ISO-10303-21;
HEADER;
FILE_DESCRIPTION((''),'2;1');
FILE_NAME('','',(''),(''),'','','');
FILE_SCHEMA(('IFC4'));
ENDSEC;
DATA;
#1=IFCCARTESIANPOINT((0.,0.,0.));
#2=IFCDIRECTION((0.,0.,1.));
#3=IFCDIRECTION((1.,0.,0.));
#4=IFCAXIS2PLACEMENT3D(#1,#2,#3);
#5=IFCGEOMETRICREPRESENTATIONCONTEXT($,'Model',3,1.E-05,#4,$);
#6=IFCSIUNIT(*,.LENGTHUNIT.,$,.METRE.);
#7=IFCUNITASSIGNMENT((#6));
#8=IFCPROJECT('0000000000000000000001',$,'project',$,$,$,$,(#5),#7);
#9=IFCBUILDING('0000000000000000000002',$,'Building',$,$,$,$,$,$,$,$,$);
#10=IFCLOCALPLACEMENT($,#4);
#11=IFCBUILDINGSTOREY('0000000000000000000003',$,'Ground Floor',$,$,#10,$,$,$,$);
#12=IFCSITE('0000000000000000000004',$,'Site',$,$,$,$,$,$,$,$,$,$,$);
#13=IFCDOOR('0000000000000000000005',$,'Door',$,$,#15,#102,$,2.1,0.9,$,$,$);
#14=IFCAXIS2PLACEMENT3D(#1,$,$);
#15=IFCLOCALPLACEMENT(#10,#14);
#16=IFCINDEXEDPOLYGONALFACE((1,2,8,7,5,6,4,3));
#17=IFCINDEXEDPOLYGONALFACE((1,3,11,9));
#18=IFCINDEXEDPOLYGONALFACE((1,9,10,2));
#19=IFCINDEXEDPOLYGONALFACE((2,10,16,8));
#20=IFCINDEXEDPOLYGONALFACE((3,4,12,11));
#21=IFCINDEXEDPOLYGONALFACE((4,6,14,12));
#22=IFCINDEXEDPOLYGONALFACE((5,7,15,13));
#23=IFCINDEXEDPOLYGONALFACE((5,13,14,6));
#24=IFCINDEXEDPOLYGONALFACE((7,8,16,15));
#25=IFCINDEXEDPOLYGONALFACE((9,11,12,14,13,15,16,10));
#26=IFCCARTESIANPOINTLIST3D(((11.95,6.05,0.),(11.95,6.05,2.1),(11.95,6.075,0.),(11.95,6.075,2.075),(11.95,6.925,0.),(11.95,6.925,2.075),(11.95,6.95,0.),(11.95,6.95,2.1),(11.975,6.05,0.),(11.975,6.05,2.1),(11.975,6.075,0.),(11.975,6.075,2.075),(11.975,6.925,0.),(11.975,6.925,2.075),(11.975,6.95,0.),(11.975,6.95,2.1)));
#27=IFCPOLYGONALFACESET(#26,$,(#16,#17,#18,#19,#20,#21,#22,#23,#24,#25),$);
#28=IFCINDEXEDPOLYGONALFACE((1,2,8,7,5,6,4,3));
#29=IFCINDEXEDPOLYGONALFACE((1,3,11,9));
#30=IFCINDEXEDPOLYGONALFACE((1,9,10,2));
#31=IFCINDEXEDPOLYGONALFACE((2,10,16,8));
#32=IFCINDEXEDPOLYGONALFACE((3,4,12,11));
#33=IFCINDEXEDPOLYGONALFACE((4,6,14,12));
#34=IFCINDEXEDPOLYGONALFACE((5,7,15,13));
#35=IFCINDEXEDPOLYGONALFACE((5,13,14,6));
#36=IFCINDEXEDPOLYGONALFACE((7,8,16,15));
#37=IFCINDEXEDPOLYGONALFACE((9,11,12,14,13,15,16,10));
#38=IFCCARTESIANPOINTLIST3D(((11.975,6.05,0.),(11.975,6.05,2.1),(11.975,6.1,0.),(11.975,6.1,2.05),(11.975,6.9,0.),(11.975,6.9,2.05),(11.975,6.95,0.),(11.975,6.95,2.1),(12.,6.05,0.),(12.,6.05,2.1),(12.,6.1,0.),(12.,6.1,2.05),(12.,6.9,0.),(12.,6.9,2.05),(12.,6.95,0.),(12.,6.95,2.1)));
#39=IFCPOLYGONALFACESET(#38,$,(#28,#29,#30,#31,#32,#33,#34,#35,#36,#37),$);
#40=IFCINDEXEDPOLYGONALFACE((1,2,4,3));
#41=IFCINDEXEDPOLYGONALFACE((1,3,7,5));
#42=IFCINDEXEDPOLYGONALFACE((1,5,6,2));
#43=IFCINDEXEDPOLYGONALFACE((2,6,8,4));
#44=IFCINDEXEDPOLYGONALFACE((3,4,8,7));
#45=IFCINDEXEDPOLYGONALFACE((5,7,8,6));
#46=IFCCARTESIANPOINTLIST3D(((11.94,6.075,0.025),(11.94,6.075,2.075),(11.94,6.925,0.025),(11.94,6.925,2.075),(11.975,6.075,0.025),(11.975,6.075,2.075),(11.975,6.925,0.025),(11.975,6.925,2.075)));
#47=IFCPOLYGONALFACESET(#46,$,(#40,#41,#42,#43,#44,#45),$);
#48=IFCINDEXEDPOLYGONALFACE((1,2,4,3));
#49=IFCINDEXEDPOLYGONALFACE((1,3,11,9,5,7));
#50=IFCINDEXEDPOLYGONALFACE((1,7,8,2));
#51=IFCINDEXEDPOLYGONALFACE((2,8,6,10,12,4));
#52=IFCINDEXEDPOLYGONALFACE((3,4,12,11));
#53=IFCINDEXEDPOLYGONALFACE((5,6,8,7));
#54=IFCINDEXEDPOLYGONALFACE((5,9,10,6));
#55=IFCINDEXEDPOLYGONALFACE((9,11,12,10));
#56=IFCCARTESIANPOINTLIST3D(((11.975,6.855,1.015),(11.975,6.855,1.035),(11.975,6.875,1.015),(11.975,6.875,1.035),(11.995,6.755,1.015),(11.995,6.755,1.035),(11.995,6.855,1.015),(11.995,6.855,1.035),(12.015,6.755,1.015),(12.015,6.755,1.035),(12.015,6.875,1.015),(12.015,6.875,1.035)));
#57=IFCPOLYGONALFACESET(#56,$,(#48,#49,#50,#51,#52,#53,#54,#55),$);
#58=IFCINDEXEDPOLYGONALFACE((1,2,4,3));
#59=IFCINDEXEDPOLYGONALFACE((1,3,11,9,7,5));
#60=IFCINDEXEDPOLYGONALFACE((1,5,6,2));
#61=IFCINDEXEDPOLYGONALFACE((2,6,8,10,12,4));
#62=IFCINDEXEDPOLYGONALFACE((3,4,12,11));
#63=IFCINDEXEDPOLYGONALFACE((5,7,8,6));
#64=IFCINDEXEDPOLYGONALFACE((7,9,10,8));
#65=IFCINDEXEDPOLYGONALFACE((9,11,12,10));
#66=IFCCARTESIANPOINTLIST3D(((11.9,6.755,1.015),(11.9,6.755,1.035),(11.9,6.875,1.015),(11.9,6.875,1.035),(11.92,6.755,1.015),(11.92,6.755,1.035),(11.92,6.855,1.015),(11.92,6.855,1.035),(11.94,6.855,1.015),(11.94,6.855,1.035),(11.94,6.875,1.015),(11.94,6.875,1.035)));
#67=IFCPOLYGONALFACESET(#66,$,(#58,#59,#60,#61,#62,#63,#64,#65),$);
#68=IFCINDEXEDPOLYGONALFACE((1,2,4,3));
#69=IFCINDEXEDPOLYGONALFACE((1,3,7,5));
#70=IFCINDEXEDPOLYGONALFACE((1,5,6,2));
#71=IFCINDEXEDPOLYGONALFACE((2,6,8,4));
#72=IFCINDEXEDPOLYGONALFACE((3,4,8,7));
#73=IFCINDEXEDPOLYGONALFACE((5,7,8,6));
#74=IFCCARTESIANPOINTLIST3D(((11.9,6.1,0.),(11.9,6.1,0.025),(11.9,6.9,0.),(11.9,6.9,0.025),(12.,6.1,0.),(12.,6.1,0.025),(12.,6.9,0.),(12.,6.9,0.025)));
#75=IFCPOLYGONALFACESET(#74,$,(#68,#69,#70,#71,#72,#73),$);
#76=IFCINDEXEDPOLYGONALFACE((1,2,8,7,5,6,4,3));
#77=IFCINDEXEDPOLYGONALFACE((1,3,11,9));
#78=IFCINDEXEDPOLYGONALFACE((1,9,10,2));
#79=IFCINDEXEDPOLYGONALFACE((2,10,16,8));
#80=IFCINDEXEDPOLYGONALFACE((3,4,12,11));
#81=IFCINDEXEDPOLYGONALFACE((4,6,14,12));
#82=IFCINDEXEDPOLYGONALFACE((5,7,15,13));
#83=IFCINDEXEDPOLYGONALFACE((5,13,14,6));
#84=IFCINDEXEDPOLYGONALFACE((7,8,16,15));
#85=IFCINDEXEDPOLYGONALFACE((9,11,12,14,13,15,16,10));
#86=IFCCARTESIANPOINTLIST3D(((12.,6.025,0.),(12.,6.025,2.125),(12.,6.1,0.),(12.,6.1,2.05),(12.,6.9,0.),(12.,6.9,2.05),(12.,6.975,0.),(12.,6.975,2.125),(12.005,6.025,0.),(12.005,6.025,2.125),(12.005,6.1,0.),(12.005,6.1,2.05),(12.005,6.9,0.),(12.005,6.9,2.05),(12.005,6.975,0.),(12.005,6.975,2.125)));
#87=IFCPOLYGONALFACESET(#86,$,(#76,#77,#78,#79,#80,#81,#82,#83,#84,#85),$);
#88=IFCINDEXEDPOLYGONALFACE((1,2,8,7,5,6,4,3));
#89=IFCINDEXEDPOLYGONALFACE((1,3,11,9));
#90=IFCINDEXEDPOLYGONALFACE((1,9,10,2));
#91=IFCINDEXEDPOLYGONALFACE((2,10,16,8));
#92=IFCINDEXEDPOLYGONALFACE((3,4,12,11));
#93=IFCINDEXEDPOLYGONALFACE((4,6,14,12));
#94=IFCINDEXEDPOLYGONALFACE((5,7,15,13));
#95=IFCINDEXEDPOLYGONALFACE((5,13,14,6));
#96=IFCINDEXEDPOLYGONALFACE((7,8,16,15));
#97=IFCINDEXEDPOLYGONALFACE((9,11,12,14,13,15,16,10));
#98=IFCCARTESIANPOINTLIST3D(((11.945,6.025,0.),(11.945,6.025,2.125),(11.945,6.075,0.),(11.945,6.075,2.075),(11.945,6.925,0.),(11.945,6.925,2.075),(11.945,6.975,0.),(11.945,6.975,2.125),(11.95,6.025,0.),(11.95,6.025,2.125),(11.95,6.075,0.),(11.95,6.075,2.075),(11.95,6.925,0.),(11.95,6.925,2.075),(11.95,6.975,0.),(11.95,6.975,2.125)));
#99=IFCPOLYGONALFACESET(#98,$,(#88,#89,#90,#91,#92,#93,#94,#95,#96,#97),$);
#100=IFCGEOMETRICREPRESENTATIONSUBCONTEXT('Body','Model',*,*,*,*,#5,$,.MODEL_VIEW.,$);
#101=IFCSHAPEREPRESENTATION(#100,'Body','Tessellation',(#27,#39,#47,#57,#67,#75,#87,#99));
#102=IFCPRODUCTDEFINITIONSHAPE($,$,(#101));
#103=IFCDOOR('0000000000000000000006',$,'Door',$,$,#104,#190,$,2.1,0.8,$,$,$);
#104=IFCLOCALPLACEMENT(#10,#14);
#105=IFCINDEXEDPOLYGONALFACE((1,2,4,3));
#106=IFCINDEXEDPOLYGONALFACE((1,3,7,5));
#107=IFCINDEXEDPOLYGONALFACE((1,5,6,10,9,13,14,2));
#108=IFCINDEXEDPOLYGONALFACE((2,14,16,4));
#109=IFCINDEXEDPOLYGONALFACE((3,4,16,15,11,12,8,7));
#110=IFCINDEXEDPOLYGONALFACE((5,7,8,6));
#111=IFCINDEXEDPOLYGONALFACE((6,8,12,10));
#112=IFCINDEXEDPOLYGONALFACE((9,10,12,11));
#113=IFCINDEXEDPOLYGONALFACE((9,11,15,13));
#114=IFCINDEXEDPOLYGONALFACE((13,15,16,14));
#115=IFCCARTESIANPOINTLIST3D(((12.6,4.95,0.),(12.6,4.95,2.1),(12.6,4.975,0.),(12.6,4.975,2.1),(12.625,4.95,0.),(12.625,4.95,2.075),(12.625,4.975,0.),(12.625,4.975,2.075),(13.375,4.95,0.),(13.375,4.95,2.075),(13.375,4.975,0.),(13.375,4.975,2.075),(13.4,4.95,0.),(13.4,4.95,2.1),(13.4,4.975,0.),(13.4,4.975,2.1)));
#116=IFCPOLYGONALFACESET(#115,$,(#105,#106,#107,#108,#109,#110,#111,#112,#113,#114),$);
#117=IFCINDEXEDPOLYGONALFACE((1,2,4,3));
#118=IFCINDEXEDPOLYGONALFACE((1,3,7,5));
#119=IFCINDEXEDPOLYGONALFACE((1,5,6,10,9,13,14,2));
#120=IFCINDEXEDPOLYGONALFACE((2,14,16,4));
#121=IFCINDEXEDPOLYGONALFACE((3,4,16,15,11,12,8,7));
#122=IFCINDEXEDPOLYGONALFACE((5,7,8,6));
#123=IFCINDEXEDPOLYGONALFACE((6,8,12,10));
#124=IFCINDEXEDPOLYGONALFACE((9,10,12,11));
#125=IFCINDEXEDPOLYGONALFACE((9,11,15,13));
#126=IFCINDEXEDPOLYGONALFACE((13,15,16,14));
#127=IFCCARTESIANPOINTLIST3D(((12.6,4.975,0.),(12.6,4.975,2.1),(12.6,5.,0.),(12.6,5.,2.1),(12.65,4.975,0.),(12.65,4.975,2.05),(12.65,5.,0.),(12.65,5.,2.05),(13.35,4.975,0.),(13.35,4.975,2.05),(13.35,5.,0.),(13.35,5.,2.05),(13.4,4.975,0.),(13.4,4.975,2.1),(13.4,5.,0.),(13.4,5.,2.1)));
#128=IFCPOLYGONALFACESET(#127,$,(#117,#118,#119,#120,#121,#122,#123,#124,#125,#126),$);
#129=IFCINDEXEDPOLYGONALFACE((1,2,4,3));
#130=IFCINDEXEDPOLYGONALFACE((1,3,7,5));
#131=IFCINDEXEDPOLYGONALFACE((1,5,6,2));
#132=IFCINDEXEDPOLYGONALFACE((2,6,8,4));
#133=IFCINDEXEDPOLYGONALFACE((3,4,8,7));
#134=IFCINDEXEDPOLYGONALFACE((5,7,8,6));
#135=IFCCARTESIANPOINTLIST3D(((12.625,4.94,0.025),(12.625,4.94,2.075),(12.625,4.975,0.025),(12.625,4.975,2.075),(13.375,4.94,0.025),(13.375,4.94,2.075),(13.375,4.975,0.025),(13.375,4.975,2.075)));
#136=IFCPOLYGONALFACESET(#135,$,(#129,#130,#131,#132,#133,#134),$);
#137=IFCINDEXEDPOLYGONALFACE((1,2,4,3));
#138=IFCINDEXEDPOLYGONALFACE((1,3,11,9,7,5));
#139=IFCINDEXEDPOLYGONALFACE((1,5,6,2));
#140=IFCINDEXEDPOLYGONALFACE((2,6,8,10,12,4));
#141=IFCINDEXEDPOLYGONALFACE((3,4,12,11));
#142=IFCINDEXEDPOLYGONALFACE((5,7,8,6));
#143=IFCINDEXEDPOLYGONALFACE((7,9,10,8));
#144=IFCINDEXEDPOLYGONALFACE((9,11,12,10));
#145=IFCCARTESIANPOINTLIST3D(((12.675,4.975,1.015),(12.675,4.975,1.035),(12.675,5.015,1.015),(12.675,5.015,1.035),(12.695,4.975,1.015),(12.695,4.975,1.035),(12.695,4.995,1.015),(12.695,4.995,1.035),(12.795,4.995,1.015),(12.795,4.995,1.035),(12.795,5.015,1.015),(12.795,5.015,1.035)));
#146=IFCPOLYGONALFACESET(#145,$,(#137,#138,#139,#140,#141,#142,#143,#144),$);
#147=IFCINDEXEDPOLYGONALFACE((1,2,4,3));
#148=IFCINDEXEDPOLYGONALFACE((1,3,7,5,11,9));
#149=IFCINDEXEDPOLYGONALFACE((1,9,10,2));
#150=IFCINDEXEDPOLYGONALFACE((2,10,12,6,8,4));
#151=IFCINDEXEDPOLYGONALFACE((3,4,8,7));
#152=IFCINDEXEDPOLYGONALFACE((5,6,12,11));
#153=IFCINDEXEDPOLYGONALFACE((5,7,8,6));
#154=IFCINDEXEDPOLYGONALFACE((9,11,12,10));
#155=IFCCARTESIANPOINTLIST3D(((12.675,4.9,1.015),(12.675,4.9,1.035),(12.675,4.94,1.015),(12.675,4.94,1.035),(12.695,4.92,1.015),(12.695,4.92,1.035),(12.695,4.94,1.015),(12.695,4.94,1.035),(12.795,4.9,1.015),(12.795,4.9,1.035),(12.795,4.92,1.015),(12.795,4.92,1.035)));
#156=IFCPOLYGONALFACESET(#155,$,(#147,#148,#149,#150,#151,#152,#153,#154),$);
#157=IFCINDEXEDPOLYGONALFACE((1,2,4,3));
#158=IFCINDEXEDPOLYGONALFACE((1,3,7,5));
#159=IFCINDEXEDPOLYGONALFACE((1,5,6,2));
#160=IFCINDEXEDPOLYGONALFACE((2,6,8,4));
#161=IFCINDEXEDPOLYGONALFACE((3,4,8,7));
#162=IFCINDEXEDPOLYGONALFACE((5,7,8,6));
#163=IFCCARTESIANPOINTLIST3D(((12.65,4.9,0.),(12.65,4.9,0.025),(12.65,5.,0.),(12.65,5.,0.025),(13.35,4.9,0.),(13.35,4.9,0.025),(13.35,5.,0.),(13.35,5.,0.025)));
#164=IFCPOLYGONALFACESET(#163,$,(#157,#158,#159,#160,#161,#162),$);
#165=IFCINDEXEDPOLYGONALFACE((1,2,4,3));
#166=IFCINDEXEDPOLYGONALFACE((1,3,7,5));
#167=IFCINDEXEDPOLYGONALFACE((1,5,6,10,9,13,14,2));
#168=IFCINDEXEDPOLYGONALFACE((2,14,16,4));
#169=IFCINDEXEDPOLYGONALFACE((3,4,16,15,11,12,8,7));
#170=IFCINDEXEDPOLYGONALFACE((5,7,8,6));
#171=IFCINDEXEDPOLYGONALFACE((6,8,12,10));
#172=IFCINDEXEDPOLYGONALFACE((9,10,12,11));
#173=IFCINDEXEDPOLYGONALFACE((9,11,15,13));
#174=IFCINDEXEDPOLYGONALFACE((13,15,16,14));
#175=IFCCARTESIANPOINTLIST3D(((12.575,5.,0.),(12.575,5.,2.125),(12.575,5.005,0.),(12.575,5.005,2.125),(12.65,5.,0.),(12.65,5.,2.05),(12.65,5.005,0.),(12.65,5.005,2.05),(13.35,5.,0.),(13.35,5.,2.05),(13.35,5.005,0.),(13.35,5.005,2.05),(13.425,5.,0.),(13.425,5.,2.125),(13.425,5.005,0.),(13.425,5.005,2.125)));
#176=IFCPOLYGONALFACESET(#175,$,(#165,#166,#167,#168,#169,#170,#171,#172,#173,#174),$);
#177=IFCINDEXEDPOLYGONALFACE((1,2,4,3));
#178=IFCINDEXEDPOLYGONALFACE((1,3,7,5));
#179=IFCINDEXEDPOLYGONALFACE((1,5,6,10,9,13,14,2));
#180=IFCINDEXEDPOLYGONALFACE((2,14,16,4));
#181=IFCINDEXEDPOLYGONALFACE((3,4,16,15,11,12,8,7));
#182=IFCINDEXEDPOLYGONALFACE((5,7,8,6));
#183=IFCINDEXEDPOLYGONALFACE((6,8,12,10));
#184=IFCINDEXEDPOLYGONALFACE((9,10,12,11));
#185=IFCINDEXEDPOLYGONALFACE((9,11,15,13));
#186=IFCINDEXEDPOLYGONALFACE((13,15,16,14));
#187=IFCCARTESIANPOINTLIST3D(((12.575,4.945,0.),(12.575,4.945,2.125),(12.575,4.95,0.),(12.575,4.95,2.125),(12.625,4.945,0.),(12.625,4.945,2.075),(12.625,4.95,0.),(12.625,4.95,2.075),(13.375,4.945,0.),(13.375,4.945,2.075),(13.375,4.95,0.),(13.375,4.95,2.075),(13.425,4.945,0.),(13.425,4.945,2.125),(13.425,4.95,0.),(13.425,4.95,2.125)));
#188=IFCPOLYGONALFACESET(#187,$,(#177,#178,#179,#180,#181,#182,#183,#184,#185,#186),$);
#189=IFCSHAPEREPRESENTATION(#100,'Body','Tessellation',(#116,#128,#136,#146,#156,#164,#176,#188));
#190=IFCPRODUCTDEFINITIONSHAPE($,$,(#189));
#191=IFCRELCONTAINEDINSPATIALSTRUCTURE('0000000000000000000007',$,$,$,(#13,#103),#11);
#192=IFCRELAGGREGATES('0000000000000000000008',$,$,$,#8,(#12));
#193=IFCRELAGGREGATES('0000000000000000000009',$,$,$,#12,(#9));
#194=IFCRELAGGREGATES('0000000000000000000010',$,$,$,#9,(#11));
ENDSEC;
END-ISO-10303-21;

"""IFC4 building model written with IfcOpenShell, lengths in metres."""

from ifc_helpers import new_model, si_unit, frame, origin_with_axes, place, context, subcontext, project, spatial, line, indexed_curve, outline, extrude, element, save


model = new_model("IFC4")

# Units and contexts
model_context = context("Model", 3, precision=1e-05, world=origin_with_axes())
body_context = subcontext(model_context, "Body", "Model", "MODEL_VIEW")
ifc_project = project(units=[si_unit("LENGTHUNIT", "METRE")], contexts=[model_context])

# Site, building, storey
site = spatial("IfcSite", under=ifc_project, Name="Site")
building = spatial("IfcBuilding", under=site, Name="Building")
storey_placement = place(None, origin_with_axes())
storey = spatial("IfcBuildingStorey", under=building, at=storey_placement, Name="Ground Floor")

# Doors
door_1_placement = place(storey_placement, frame((12.0, 6.05, 0.0), z_axis=(0.0, 0.0, 1.0), x_axis=(0.0, 1.0, 0.0)))
element("IfcDoor", 1, at=door_1_placement, inside=storey, Name="Door", OverallHeight=2.1, OverallWidth=0.9, context=body_context, shape_type="SweptSolid", body=[
    extrude(outline(indexed_curve([(0.0, 0.0), (0.0, 2.1), (0.9, 2.1), (0.9, 0.0), (0.875, 0.0), (0.875, 2.075), (0.025, 2.075), (0.025, 0.0)], segments=[line(1, 2, 3, 4, 5, 6, 7, 8, 1)])), frame((0.0, 0.025, 0.0), z_axis=(0.0, -1.0, 0.0), x_axis=(1.0, 0.0, 0.0)), (0.0, 0.0, -1.0), 0.025),
    extrude(outline(indexed_curve([(0.0, 0.0), (0.0, 2.1), (0.9, 2.1), (0.9, 0.0), (0.85, 0.0), (0.85, 2.05), (0.05, 2.05), (0.05, 0.0)], segments=[line(1, 2, 3, 4, 5, 6, 7, 8, 1)])), frame((0.0, 0.0, 0.0), z_axis=(0.0, -1.0, 0.0), x_axis=(1.0, 0.0, 0.0)), (0.0, 0.0, -1.0), 0.025),
    extrude(outline(indexed_curve([(0.0, 0.0), (0.85, 0.0), (0.85, 0.035), (0.0, 0.035)], segments=[line(1, 2, 3, 4, 1)])), frame((0.025, 0.025, 0.025), z_axis=(0.0, 0.0, 1.0), x_axis=(1.0, 0.0, 0.0)), (0.0, 0.0, 1.0), 2.05),
    extrude(outline(indexed_curve([(0.0, 0.0), (0.0, -0.04), (-0.12, -0.04), (-0.12, -0.02), (-0.02, -0.02), (-0.02, 0.0)], segments=[line(1, 2, 3, 4, 5, 6, 1)])), frame((0.825, 0.025, 1.015), z_axis=(0.0, 0.0, 1.0), x_axis=(1.0, 0.0, 0.0)), (0.0, 0.0, 1.0), 0.02),
    extrude(outline(indexed_curve([(0.0, 0.0), (0.0, 0.04), (-0.12, 0.04), (-0.12, 0.02), (-0.02, 0.02), (-0.02, 0.0)], segments=[line(1, 2, 3, 4, 5, 6, 1)])), frame((0.825, 0.06, 1.015), z_axis=(0.0, 0.0, 1.0), x_axis=(1.0, 0.0, 0.0)), (0.0, 0.0, 1.0), 0.02),
    extrude(outline(indexed_curve([(0.0, 0.0), (0.8, 0.0), (0.8, 0.1), (0.0, 0.1)], segments=[line(1, 2, 3, 4, 1)])), frame((0.05, 0.0, 0.0), z_axis=(0.0, 0.0, 1.0), x_axis=(1.0, 0.0, 0.0)), (0.0, 0.0, 1.0), 0.025),
    extrude(outline(indexed_curve([(0.0, 0.0), (0.0, 2.125), (0.95, 2.125), (0.95, 0.0), (0.875, 0.0), (0.875, 2.05), (0.075, 2.05), (0.075, 0.0)], segments=[line(1, 2, 3, 4, 5, 6, 7, 8, 1)])), frame((-0.025, -0.005, 0.0), z_axis=(0.0, -1.0, 0.0), x_axis=(1.0, 0.0, 0.0)), (0.0, 0.0, -1.0), 0.005),
    extrude(outline(indexed_curve([(0.0, 0.0), (0.0, 2.125), (0.95, 2.125), (0.95, 0.0), (0.9, 0.0), (0.9, 2.075), (0.05, 2.075), (0.05, 0.0)], segments=[line(1, 2, 3, 4, 5, 6, 7, 8, 1)])), frame((-0.025, 0.05, 0.0), z_axis=(0.0, -1.0, 0.0), x_axis=(1.0, 0.0, 0.0)), (0.0, 0.0, -1.0), 0.005),
])
door_2_placement = place(storey_placement, frame((13.4, 5.0, 0.0), z_axis=(0.0, 0.0, 1.0), x_axis=(-1.0, 0.0, 0.0)))
element("IfcDoor", 2, at=door_2_placement, inside=storey, Name="Door", OverallHeight=2.1, OverallWidth=0.8, context=body_context, shape_type="SweptSolid", body=[
    extrude(outline(indexed_curve([(0.0, 0.0), (0.0, 2.1), (0.8, 2.1), (0.8, 0.0), (0.775, 0.0), (0.775, 2.075), (0.025, 2.075), (0.025, 0.0)], segments=[line(1, 2, 3, 4, 5, 6, 7, 8, 1)])), frame((0.0, 0.025, 0.0), z_axis=(0.0, -1.0, 0.0), x_axis=(1.0, 0.0, 0.0)), (0.0, 0.0, -1.0), 0.025),
    extrude(outline(indexed_curve([(0.0, 0.0), (0.0, 2.1), (0.8, 2.1), (0.8, 0.0), (0.75, 0.0), (0.75, 2.05), (0.05, 2.05), (0.05, 0.0)], segments=[line(1, 2, 3, 4, 5, 6, 7, 8, 1)])), frame((0.0, 0.0, 0.0), z_axis=(0.0, -1.0, 0.0), x_axis=(1.0, 0.0, 0.0)), (0.0, 0.0, -1.0), 0.025),
    extrude(outline(indexed_curve([(0.0, 0.0), (0.75, 0.0), (0.75, 0.035), (0.0, 0.035)], segments=[line(1, 2, 3, 4, 1)])), frame((0.025, 0.025, 0.025), z_axis=(0.0, 0.0, 1.0), x_axis=(1.0, 0.0, 0.0)), (0.0, 0.0, 1.0), 2.05),
    extrude(outline(indexed_curve([(0.0, 0.0), (0.0, -0.04), (-0.12, -0.04), (-0.12, -0.02), (-0.02, -0.02), (-0.02, 0.0)], segments=[line(1, 2, 3, 4, 5, 6, 1)])), frame((0.725, 0.025, 1.015), z_axis=(0.0, 0.0, 1.0), x_axis=(1.0, 0.0, 0.0)), (0.0, 0.0, 1.0), 0.02),
    extrude(outline(indexed_curve([(0.0, 0.0), (0.0, 0.04), (-0.12, 0.04), (-0.12, 0.02), (-0.02, 0.02), (-0.02, 0.0)], segments=[line(1, 2, 3, 4, 5, 6, 1)])), frame((0.725, 0.06, 1.015), z_axis=(0.0, 0.0, 1.0), x_axis=(1.0, 0.0, 0.0)), (0.0, 0.0, 1.0), 0.02),
    extrude(outline(indexed_curve([(0.0, 0.0), (0.7, 0.0), (0.7, 0.1), (0.0, 0.1)], segments=[line(1, 2, 3, 4, 1)])), frame((0.05, 0.0, 0.0), z_axis=(0.0, 0.0, 1.0), x_axis=(1.0, 0.0, 0.0)), (0.0, 0.0, 1.0), 0.025),
    extrude(outline(indexed_curve([(0.0, 0.0), (0.0, 2.125), (0.85, 2.125), (0.85, 0.0), (0.775, 0.0), (0.775, 2.05), (0.075, 2.05), (0.075, 0.0)], segments=[line(1, 2, 3, 4, 5, 6, 7, 8, 1)])), frame((-0.025, -0.005, 0.0), z_axis=(0.0, -1.0, 0.0), x_axis=(1.0, 0.0, 0.0)), (0.0, 0.0, -1.0), 0.005),
    extrude(outline(indexed_curve([(0.0, 0.0), (0.0, 2.125), (0.85, 2.125), (0.85, 0.0), (0.8, 0.0), (0.8, 2.075), (0.05, 2.075), (0.05, 0.0)], segments=[line(1, 2, 3, 4, 5, 6, 7, 8, 1)])), frame((-0.025, 0.05, 0.0), z_axis=(0.0, -1.0, 0.0), x_axis=(1.0, 0.0, 0.0)), (0.0, 0.0, -1.0), 0.005),
])

save(model, "model.ifc")
